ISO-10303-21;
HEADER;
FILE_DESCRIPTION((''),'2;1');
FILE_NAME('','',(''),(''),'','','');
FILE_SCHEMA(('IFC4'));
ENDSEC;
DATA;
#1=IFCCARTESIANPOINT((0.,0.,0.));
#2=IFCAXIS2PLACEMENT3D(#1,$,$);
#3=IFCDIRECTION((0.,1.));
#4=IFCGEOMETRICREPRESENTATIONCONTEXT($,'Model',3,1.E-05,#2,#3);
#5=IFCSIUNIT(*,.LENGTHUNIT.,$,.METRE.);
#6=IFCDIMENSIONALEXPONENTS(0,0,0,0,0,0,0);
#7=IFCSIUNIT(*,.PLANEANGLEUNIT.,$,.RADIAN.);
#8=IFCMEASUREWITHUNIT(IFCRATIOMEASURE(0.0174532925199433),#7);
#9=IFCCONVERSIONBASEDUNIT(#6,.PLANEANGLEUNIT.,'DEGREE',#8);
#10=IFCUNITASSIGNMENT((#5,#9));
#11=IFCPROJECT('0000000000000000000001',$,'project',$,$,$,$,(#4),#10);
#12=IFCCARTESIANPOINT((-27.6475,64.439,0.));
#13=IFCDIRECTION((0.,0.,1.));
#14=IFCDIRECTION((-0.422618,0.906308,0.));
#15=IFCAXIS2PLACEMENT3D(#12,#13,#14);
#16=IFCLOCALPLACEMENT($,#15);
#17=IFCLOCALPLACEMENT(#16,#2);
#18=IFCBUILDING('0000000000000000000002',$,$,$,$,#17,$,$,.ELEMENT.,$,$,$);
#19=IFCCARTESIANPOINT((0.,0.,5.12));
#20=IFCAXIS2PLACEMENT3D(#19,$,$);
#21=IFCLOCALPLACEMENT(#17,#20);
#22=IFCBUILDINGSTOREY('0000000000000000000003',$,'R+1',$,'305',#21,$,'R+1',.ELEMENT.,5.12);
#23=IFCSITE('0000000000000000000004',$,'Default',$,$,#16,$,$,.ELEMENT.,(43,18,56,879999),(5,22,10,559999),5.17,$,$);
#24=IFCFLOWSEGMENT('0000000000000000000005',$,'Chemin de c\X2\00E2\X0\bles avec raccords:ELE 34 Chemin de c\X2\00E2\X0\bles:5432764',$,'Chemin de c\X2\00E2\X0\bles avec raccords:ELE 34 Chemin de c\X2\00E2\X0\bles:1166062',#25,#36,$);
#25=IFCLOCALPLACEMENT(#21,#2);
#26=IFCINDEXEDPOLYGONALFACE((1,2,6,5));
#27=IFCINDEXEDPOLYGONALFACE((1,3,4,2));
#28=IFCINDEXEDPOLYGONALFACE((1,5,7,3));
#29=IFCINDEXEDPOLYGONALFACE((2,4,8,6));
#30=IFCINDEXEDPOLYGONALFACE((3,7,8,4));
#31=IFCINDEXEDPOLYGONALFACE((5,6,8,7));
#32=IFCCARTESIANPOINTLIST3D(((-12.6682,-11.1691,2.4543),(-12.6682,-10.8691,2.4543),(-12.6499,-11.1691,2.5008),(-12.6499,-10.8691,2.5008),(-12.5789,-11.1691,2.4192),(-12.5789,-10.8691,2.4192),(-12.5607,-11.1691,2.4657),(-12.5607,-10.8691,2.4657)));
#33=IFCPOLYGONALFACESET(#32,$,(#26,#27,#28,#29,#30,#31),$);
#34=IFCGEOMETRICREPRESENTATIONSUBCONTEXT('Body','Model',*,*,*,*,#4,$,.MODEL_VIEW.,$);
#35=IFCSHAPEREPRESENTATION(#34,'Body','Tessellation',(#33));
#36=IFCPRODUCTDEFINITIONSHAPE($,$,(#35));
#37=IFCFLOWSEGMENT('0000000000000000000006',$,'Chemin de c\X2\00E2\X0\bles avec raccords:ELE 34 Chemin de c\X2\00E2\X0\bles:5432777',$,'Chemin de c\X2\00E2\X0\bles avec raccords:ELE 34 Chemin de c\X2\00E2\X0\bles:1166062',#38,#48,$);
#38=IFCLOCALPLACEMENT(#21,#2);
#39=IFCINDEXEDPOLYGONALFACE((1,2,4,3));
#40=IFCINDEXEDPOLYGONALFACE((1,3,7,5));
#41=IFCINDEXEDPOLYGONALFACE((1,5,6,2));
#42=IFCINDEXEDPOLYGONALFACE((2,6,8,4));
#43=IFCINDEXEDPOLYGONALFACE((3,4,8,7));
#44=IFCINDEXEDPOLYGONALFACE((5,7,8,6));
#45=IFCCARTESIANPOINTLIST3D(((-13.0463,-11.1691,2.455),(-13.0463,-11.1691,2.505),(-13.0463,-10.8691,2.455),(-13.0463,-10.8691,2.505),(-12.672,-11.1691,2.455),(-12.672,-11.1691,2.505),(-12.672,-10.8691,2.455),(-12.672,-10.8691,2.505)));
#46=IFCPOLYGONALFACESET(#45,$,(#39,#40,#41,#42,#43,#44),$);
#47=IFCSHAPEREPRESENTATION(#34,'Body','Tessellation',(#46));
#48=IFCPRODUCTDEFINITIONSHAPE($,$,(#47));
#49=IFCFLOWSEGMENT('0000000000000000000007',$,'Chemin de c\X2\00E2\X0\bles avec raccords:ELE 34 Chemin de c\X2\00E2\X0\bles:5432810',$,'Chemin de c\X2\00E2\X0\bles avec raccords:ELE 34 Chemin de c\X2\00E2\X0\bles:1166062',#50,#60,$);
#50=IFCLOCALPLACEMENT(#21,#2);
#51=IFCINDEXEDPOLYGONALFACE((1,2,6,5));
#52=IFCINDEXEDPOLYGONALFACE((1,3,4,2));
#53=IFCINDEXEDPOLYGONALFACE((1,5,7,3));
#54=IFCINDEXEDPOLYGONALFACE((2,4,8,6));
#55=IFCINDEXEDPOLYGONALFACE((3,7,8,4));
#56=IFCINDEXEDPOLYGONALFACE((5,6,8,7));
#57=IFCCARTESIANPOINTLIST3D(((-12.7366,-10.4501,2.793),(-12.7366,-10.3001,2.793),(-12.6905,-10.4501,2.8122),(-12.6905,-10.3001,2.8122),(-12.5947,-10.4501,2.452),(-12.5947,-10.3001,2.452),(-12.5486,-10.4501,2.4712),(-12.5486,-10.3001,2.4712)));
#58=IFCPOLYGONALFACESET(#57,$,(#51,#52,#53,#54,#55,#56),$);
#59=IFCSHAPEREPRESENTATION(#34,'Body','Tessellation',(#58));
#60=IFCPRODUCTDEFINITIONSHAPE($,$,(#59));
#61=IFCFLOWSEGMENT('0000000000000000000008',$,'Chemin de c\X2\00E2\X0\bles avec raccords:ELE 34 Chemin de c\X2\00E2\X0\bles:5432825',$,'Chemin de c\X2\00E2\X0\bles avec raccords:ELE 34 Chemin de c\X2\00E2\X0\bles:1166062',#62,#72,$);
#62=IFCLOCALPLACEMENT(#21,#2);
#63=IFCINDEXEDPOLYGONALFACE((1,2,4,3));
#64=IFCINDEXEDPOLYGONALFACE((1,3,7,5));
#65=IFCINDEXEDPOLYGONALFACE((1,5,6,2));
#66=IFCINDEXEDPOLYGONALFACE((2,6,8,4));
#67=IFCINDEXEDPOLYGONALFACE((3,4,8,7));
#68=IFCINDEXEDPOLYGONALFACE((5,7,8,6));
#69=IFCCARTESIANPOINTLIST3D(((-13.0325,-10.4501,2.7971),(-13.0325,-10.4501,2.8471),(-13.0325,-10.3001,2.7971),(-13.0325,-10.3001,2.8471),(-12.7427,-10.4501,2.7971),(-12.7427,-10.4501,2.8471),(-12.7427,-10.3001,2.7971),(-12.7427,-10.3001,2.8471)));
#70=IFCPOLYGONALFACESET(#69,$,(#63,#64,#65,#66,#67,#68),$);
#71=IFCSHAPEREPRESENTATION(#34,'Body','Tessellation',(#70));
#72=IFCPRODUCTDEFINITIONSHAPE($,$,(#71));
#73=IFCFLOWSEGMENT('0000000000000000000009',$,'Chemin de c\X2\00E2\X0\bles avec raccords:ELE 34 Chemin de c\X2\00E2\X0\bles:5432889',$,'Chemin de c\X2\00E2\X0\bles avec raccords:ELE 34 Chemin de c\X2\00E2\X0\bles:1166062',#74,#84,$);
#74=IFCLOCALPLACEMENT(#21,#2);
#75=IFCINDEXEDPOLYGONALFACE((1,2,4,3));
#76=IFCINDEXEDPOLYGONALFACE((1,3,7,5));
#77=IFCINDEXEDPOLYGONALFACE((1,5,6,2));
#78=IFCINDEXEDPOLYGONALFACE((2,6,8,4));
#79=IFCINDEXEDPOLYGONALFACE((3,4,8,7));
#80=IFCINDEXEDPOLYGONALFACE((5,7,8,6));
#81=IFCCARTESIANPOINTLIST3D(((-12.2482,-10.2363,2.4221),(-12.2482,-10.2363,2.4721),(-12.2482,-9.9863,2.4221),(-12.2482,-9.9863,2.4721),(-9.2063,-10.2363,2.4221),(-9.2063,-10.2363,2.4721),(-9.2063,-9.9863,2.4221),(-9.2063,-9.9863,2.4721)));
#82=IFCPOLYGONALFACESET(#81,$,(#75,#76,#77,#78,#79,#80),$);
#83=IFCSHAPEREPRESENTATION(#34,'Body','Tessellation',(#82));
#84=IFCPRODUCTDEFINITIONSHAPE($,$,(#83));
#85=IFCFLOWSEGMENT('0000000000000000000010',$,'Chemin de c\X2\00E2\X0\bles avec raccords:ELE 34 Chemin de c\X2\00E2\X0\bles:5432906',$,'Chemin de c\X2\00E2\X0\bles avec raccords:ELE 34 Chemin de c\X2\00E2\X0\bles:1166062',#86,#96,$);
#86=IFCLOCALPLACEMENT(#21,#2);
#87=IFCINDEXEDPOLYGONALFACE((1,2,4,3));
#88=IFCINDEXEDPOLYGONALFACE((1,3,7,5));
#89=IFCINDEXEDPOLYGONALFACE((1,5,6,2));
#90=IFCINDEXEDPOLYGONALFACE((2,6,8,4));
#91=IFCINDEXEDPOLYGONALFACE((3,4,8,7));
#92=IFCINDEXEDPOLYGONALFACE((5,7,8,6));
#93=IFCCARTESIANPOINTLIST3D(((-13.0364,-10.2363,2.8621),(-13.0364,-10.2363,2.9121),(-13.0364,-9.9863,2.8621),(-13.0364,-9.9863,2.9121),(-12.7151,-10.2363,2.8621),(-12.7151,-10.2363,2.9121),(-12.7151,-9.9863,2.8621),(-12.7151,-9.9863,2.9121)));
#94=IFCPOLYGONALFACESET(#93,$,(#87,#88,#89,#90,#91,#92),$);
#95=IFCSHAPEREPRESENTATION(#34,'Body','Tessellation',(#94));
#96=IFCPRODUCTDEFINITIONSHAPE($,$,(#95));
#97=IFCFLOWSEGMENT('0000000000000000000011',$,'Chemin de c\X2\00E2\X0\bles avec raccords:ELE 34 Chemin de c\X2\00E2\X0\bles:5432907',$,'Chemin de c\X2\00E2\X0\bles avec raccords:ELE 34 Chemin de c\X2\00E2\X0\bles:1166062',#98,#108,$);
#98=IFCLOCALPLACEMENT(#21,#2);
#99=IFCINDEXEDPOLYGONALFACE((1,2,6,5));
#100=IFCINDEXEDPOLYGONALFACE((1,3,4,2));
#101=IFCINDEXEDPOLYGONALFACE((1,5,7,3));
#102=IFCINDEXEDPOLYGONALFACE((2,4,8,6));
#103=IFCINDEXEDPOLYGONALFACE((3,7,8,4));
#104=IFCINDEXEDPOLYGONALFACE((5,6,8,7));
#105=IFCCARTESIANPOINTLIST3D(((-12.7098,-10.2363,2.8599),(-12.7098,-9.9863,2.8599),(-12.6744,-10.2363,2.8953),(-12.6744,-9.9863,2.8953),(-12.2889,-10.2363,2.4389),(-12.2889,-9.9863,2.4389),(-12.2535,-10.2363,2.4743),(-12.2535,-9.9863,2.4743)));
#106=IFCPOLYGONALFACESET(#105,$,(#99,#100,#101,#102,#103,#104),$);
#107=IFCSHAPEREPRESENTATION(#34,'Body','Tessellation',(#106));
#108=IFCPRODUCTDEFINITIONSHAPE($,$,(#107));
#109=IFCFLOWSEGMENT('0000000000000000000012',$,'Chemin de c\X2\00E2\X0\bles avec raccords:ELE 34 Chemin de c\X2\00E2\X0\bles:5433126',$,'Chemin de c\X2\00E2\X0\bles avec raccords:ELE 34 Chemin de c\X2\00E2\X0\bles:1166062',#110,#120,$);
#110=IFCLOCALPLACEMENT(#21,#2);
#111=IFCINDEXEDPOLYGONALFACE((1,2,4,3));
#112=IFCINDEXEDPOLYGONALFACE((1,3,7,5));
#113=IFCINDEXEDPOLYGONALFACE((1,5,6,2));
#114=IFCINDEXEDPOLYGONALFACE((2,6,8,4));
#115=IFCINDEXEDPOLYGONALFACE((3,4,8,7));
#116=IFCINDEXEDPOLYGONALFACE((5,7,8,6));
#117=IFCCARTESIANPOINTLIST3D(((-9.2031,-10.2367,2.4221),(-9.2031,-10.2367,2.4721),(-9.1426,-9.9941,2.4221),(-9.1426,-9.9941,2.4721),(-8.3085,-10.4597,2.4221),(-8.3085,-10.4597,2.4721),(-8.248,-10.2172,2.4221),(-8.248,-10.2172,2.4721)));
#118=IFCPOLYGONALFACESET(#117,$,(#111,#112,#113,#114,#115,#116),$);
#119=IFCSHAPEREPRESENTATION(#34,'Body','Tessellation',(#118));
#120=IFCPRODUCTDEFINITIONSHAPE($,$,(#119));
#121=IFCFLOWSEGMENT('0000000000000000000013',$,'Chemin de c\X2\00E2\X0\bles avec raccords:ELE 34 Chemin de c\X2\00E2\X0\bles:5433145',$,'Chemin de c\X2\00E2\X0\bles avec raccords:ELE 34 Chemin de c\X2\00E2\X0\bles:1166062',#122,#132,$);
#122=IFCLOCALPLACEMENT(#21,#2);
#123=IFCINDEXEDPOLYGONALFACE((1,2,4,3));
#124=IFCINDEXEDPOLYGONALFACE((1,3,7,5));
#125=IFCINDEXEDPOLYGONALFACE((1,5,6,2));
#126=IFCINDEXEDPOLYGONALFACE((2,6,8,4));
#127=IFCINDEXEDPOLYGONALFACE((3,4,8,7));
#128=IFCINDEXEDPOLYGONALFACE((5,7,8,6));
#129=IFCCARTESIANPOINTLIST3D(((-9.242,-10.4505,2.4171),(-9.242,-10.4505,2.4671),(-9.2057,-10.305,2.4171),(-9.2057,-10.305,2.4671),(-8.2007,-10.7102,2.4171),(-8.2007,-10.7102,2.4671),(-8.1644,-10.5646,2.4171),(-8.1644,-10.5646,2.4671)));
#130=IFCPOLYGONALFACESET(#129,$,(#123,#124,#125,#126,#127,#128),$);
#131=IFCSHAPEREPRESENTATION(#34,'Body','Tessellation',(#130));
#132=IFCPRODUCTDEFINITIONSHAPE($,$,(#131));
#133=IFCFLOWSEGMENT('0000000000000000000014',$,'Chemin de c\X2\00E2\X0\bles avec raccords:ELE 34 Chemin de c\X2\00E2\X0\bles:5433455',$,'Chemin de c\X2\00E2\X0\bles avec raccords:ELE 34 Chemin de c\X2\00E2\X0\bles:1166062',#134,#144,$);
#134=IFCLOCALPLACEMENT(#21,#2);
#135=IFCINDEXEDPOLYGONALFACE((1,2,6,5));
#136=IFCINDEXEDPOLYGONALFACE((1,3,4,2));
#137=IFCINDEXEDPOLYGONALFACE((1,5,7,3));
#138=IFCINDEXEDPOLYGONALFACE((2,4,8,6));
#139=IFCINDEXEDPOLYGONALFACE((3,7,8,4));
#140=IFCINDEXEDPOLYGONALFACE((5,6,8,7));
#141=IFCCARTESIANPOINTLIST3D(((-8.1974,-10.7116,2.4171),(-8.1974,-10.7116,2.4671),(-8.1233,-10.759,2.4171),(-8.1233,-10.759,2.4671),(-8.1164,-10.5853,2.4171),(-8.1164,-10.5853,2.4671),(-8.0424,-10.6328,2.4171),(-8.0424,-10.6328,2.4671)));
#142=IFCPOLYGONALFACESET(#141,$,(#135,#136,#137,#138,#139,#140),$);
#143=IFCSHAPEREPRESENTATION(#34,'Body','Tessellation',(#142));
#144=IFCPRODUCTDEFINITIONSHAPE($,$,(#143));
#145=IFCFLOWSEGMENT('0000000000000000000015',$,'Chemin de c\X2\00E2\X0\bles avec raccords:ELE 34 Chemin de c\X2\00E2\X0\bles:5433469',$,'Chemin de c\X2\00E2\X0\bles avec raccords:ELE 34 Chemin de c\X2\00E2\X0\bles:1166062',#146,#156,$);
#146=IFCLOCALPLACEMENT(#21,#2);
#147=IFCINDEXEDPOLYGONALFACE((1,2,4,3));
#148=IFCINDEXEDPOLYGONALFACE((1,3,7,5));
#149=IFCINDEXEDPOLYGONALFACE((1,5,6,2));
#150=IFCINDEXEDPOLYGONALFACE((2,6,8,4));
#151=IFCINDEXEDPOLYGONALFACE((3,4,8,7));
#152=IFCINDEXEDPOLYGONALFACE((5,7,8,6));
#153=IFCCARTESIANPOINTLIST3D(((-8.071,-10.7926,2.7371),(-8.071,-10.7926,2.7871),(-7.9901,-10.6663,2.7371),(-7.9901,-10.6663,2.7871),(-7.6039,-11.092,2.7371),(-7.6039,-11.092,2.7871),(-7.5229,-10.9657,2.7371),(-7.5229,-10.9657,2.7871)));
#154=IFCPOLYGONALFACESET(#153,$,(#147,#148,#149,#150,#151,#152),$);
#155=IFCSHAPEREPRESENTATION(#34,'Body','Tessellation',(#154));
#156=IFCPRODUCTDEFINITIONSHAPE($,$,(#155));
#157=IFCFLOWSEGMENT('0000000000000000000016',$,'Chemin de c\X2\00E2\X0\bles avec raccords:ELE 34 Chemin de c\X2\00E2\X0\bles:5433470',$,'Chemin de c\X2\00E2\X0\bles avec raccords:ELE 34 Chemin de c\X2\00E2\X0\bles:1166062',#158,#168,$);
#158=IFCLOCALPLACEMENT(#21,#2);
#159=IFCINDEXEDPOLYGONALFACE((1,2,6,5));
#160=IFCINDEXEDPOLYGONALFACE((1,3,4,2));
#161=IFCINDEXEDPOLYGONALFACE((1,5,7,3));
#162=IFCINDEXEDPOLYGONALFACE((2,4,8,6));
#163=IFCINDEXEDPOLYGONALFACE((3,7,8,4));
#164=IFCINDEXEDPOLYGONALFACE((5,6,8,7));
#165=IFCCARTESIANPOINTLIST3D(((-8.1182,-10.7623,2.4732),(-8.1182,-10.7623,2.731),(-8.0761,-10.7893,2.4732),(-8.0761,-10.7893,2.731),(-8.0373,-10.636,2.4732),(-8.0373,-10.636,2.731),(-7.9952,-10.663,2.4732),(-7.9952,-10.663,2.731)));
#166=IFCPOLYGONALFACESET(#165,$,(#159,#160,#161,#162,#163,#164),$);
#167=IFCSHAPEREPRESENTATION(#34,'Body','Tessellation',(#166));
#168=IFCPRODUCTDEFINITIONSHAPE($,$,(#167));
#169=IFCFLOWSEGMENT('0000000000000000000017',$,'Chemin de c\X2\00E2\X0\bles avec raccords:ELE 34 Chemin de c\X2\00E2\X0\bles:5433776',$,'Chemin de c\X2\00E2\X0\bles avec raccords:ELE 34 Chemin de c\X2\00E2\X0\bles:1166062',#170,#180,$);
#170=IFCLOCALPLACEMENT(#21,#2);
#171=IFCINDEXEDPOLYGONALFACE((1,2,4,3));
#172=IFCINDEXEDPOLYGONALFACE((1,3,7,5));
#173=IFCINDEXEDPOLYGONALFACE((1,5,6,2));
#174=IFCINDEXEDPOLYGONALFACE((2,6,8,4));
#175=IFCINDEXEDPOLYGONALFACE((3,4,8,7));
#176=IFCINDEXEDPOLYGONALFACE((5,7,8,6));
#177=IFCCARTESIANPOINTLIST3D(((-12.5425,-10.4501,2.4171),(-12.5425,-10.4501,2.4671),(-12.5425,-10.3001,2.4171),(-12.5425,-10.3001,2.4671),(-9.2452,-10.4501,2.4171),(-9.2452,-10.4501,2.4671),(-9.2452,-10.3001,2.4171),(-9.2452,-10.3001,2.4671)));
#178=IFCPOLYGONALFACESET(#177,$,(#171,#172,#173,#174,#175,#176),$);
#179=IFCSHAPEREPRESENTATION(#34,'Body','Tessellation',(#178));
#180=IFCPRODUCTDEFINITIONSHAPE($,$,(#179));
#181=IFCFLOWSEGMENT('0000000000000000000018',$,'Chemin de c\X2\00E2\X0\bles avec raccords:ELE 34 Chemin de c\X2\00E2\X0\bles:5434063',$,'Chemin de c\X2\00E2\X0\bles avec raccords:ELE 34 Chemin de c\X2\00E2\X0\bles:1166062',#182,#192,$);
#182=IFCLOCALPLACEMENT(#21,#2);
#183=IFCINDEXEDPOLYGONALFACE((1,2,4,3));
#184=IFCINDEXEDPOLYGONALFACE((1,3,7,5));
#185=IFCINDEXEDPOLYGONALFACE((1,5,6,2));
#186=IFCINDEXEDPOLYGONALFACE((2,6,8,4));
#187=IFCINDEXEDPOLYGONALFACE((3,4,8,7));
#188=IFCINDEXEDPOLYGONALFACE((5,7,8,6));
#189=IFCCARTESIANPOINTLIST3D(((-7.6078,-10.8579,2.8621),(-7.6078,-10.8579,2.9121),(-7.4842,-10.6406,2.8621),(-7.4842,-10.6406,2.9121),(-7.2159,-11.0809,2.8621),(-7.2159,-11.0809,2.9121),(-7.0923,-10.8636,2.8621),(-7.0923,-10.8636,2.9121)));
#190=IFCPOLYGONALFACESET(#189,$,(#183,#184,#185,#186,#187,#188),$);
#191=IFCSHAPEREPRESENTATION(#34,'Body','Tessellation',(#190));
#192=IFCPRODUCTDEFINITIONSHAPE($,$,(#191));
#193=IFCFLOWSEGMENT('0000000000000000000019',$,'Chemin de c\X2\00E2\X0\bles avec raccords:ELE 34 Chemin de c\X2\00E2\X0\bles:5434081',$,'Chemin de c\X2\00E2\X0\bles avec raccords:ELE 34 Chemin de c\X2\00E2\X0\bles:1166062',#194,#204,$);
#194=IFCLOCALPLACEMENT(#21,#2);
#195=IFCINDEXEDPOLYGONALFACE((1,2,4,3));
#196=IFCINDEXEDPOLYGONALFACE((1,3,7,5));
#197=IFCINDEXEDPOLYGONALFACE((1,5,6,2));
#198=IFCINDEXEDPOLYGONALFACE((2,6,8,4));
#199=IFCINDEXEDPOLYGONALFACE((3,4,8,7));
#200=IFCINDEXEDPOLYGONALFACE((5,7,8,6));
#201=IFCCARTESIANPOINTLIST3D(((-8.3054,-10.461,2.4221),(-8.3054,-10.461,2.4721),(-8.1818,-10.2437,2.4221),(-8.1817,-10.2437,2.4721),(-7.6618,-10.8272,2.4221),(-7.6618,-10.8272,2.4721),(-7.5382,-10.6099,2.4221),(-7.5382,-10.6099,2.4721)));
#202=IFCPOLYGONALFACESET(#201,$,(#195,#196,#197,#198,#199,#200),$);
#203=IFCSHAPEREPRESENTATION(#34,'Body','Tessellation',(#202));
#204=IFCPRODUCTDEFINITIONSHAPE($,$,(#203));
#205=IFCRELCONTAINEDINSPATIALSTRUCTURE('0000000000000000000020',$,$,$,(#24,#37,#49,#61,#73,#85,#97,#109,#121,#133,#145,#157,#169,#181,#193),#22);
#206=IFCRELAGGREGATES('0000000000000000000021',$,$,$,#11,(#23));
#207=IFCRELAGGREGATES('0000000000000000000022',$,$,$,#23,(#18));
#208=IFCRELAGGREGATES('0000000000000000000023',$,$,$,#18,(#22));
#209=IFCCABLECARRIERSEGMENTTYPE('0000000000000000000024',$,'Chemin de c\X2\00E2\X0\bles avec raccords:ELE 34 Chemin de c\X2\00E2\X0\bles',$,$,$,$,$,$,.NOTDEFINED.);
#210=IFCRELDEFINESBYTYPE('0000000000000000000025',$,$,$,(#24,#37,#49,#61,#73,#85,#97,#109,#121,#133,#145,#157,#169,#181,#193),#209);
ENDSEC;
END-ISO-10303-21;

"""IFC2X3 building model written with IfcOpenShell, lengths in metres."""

from ifc_helpers import new_model, entity, si_unit, converted_unit, direction, frame, frame_2d, origin, origin_2d_with_axis, place, context, subcontext, project, spatial, rectangle, extrude, type_object, element, save


model = new_model("IFC2X3")

# Units and contexts
model_context = context("Model", 3, precision=1e-05, world=origin(), true_north=direction((0.0, 1.0)))
body_context = subcontext(model_context, "Body", "Model", "MODEL_VIEW")
ifc_project = project(units=[si_unit("LENGTHUNIT", "METRE"), converted_unit("PLANEANGLEUNIT", "DEGREE", entity("IfcRatioMeasure", 0.0174532925199433), si_unit("PLANEANGLEUNIT", "RADIAN"), dimensions=[0, 0, 0, 0, 0, 0, 0])], contexts=[model_context])

# Site, building, storey
site_placement = place(None, frame((-27.6475, 64.439, 0.0), z_axis=(0.0, 0.0, 1.0), x_axis=(-0.422618, 0.906308, 0.0)))
site = spatial("IfcSite", under=ifc_project, at=site_placement, Name="Default", CompositionType="ELEMENT", RefLatitude=(43, 18, 56, 879999), RefLongitude=(5, 22, 10, 559999), RefElevation=5.17)
building_placement = place(site_placement, origin())
building = spatial("IfcBuilding", under=site, at=building_placement, CompositionType="ELEMENT")
storey_placement = place(building_placement, frame((0.0, 0.0, 5.12)))
storey = spatial("IfcBuildingStorey", under=building, at=storey_placement, Name="R+1", ObjectType="305", LongName="R+1", CompositionType="ELEMENT", Elevation=5.12)

# Flow segments
cable_carrier_segment_type = type_object("IfcCableCarrierSegmentType", Name="Chemin de câbles avec raccords:ELE 34 Chemin de câbles", PredefinedType="NOTDEFINED")
flow_segment_1_placement = place(storey_placement, origin())
element("IfcFlowSegment", 1, at=flow_segment_1_placement, inside=storey, type_object=cable_carrier_segment_type, Name="Chemin de câbles avec raccords:ELE 34 Chemin de câbles:5432764", ObjectType="Chemin de câbles avec raccords:ELE 34 Chemin de câbles:1166062", context=body_context, shape_type="SweptSolid", body=[
    extrude(rectangle(XDim=0.05, YDim=0.0959, at=frame_2d((0.0, 0.0), x_axis=(0.0, 1.0))), frame((-12.6144, -11.1691, 2.46), z_axis=(0.0, 1.0, 0.0), x_axis=(-0.930652, 0.0, 0.365904)), (0.0, 0.0, 1.0), 0.3),
])
flow_segment_2_placement = place(storey_placement, origin())
element("IfcFlowSegment", 2, at=flow_segment_2_placement, inside=storey, type_object=cable_carrier_segment_type, Name="Chemin de câbles avec raccords:ELE 34 Chemin de câbles:5432777", ObjectType="Chemin de câbles avec raccords:ELE 34 Chemin de câbles:1166062", context=body_context, shape_type="SweptSolid", body=[
    extrude(rectangle(XDim=0.3743, YDim=0.3, at=origin_2d_with_axis()), frame((-12.8591, -11.0191, 2.455)), (0.0, 0.0, 1.0), 0.05),
])
flow_segment_3_placement = place(storey_placement, origin())
element("IfcFlowSegment", 3, at=flow_segment_3_placement, inside=storey, type_object=cable_carrier_segment_type, Name="Chemin de câbles avec raccords:ELE 34 Chemin de câbles:5432810", ObjectType="Chemin de câbles avec raccords:ELE 34 Chemin de câbles:1166062", context=body_context, shape_type="SweptSolid", body=[
    extrude(rectangle(XDim=0.05, YDim=0.15, at=frame_2d((0.0, 0.0), x_axis=(0.0, 1.0))), frame((-12.5717, -10.3751, 2.4616), z_axis=(-0.384113, 0.0, 0.923286), x_axis=(0.0, -1.0, 0.0)), (0.0, 0.0, 1.0), 0.3694),
])
flow_segment_4_placement = place(storey_placement, origin())
element("IfcFlowSegment", 4, at=flow_segment_4_placement, inside=storey, type_object=cable_carrier_segment_type, Name="Chemin de câbles avec raccords:ELE 34 Chemin de câbles:5432825", ObjectType="Chemin de câbles avec raccords:ELE 34 Chemin de câbles:1166062", context=body_context, shape_type="SweptSolid", body=[
    extrude(rectangle(XDim=0.2898, YDim=0.15, at=frame_2d((0.0, 0.0), x_axis=(1.0, 0.0))), frame((-12.8876, -10.3751, 2.7971)), (0.0, 0.0, 1.0), 0.05),
])
flow_segment_5_placement = place(storey_placement, origin())
element("IfcFlowSegment", 5, at=flow_segment_5_placement, inside=storey, type_object=cable_carrier_segment_type, Name="Chemin de câbles avec raccords:ELE 34 Chemin de câbles:5432889", ObjectType="Chemin de câbles avec raccords:ELE 34 Chemin de câbles:1166062", context=body_context, shape_type="SweptSolid", body=[
    extrude(rectangle(XDim=0.25, YDim=3.0419, at=frame_2d((0.0, 0.0), x_axis=(0.0, 1.0))), frame((-10.7273, -10.1113, 2.4221), z_axis=(-0.000004, -0.000068, 1.0), x_axis=(1.0, 0.0, 0.000004)), (0.0, 0.0, 1.0), 0.05),
])
flow_segment_6_placement = place(storey_placement, origin())
element("IfcFlowSegment", 6, at=flow_segment_6_placement, inside=storey, type_object=cable_carrier_segment_type, Name="Chemin de câbles avec raccords:ELE 34 Chemin de câbles:5432906", ObjectType="Chemin de câbles avec raccords:ELE 34 Chemin de câbles:1166062", context=body_context, shape_type="SweptSolid", body=[
    extrude(rectangle(XDim=0.3213, YDim=0.25, at=frame_2d((0.0, 0.0), x_axis=(1.0, 0.0))), frame((-12.8757, -10.1113, 2.8621)), (0.0, 0.0, 1.0), 0.05),
])
flow_segment_7_placement = place(storey_placement, origin())
element("IfcFlowSegment", 7, at=flow_segment_7_placement, inside=storey, type_object=cable_carrier_segment_type, Name="Chemin de câbles avec raccords:ELE 34 Chemin de câbles:5432907", ObjectType="Chemin de câbles avec raccords:ELE 34 Chemin de câbles:1166062", context=body_context, shape_type="SweptSolid", body=[
    extrude(rectangle(XDim=0.05, YDim=0.25, at=frame_2d((0.0, 0.0), x_axis=(0.0, 1.0))), frame((-12.6921, -10.1113, 2.8776), z_axis=(0.707108, 0.0, -0.707106), x_axis=(0.0, 1.0, 0.0)), (0.0, 0.0, 1.0), 0.5953),
])
flow_segment_8_placement = place(storey_placement, origin())
element("IfcFlowSegment", 8, at=flow_segment_8_placement, inside=storey, type_object=cable_carrier_segment_type, Name="Chemin de câbles avec raccords:ELE 34 Chemin de câbles:5433126", ObjectType="Chemin de câbles avec raccords:ELE 34 Chemin de câbles:1166062", context=body_context, shape_type="SweptSolid", body=[
    extrude(rectangle(XDim=0.922, YDim=0.25, at=frame_2d((0.0, 0.0), x_axis=(1.0, 0.0))), frame((-8.7256, -10.2269, 2.4221), z_axis=(0.000016, 0.000012, 1.0), x_axis=(0.970296, -0.241922, -0.000013)), (0.0, 0.0, 1.0), 0.05),
])
flow_segment_9_placement = place(storey_placement, origin())
element("IfcFlowSegment", 9, at=flow_segment_9_placement, inside=storey, type_object=cable_carrier_segment_type, Name="Chemin de câbles avec raccords:ELE 34 Chemin de câbles:5433145", ObjectType="Chemin de câbles avec raccords:ELE 34 Chemin de câbles:1166062", context=body_context, shape_type="SweptSolid", body=[
    extrude(rectangle(XDim=1.0732, YDim=0.15, at=frame_2d((0.0, 0.0), x_axis=(1.0, 0.0))), frame((-8.7032, -10.5076, 2.4171), z_axis=(0.0, 0.0, 1.0), x_axis=(-0.970296, 0.241922, 0.0)), (0.0, 0.0, 1.0), 0.05),
])
flow_segment_10_placement = place(storey_placement, origin())
element("IfcFlowSegment", 10, at=flow_segment_10_placement, inside=storey, type_object=cable_carrier_segment_type, Name="Chemin de câbles avec raccords:ELE 34 Chemin de câbles:5433455", ObjectType="Chemin de câbles avec raccords:ELE 34 Chemin de câbles:1166062", context=body_context, shape_type="SweptSolid", body=[
    extrude(rectangle(XDim=0.0879, YDim=0.15, at=frame_2d((0.0, 0.0), x_axis=(1.0, 0.0))), frame((-8.1199, -10.6722, 2.4171), z_axis=(0.0, 0.0, 1.0), x_axis=(0.84189, -0.539649, 0.0)), (0.0, 0.0, 1.0), 0.05),
])
flow_segment_11_placement = place(storey_placement, origin())
element("IfcFlowSegment", 11, at=flow_segment_11_placement, inside=storey, type_object=cable_carrier_segment_type, Name="Chemin de câbles avec raccords:ELE 34 Chemin de câbles:5433469", ObjectType="Chemin de câbles avec raccords:ELE 34 Chemin de câbles:1166062", context=body_context, shape_type="SweptSolid", body=[
    extrude(rectangle(XDim=0.5548, YDim=0.15, at=origin_2d_with_axis()), frame((-7.797, -10.8792, 2.7371), z_axis=(0.0, 0.0, 1.0), x_axis=(-0.84189, 0.539649, 0.0)), (0.0, 0.0, 1.0), 0.05),
])
flow_segment_12_placement = place(storey_placement, origin())
element("IfcFlowSegment", 12, at=flow_segment_12_placement, inside=storey, type_object=cable_carrier_segment_type, Name="Chemin de câbles avec raccords:ELE 34 Chemin de câbles:5433470", ObjectType="Chemin de câbles avec raccords:ELE 34 Chemin de câbles:1166062", context=body_context, shape_type="SweptSolid", body=[
    extrude(rectangle(XDim=0.05, YDim=0.15, at=origin_2d_with_axis()), frame((-8.0567, -10.7127, 2.4732), z_axis=(0.0, 0.0, 1.0), x_axis=(-0.84189, 0.539649, 0.0)), (0.0, 0.0, 1.0), 0.2578),
])
flow_segment_13_placement = place(storey_placement, origin())
element("IfcFlowSegment", 13, at=flow_segment_13_placement, inside=storey, type_object=cable_carrier_segment_type, Name="Chemin de câbles avec raccords:ELE 34 Chemin de câbles:5433776", ObjectType="Chemin de câbles avec raccords:ELE 34 Chemin de câbles:1166062", context=body_context, shape_type="SweptSolid", body=[
    extrude(rectangle(XDim=3.2973, YDim=0.15, at=origin_2d_with_axis()), frame((-10.8939, -10.3751, 2.4171)), (0.0, 0.0, 1.0), 0.05),
])
flow_segment_14_placement = place(storey_placement, origin())
element("IfcFlowSegment", 14, at=flow_segment_14_placement, inside=storey, type_object=cable_carrier_segment_type, Name="Chemin de câbles avec raccords:ELE 34 Chemin de câbles:5434063", ObjectType="Chemin de câbles avec raccords:ELE 34 Chemin de câbles:1166062", context=body_context, shape_type="SweptSolid", body=[
    extrude(rectangle(XDim=0.4509, YDim=0.25, at=frame_2d((0.0, 0.0), x_axis=(1.0, 0.0))), frame((-7.35, -10.8608, 2.8621), z_axis=(0.000007, -0.000004, 1.0), x_axis=(0.869153, -0.494544, -0.000008)), (0.0, 0.0, 1.0), 0.05),
])
flow_segment_15_placement = place(storey_placement, origin())
element("IfcFlowSegment", 15, at=flow_segment_15_placement, inside=storey, type_object=cable_carrier_segment_type, Name="Chemin de câbles avec raccords:ELE 34 Chemin de câbles:5434081", ObjectType="Chemin de câbles avec raccords:ELE 34 Chemin de câbles:1166062", context=body_context, shape_type="SweptSolid", body=[
    extrude(rectangle(XDim=0.7405, YDim=0.25, at=frame_2d((0.0, 0.0), x_axis=(1.0, 0.0))), frame((-7.9218, -10.5354, 2.4221), z_axis=(0.000016, 0.000012, 1.0), x_axis=(0.869153, -0.494544, -0.000008)), (0.0, 0.0, 1.0), 0.05),
])

save(model, "model.ifc")
